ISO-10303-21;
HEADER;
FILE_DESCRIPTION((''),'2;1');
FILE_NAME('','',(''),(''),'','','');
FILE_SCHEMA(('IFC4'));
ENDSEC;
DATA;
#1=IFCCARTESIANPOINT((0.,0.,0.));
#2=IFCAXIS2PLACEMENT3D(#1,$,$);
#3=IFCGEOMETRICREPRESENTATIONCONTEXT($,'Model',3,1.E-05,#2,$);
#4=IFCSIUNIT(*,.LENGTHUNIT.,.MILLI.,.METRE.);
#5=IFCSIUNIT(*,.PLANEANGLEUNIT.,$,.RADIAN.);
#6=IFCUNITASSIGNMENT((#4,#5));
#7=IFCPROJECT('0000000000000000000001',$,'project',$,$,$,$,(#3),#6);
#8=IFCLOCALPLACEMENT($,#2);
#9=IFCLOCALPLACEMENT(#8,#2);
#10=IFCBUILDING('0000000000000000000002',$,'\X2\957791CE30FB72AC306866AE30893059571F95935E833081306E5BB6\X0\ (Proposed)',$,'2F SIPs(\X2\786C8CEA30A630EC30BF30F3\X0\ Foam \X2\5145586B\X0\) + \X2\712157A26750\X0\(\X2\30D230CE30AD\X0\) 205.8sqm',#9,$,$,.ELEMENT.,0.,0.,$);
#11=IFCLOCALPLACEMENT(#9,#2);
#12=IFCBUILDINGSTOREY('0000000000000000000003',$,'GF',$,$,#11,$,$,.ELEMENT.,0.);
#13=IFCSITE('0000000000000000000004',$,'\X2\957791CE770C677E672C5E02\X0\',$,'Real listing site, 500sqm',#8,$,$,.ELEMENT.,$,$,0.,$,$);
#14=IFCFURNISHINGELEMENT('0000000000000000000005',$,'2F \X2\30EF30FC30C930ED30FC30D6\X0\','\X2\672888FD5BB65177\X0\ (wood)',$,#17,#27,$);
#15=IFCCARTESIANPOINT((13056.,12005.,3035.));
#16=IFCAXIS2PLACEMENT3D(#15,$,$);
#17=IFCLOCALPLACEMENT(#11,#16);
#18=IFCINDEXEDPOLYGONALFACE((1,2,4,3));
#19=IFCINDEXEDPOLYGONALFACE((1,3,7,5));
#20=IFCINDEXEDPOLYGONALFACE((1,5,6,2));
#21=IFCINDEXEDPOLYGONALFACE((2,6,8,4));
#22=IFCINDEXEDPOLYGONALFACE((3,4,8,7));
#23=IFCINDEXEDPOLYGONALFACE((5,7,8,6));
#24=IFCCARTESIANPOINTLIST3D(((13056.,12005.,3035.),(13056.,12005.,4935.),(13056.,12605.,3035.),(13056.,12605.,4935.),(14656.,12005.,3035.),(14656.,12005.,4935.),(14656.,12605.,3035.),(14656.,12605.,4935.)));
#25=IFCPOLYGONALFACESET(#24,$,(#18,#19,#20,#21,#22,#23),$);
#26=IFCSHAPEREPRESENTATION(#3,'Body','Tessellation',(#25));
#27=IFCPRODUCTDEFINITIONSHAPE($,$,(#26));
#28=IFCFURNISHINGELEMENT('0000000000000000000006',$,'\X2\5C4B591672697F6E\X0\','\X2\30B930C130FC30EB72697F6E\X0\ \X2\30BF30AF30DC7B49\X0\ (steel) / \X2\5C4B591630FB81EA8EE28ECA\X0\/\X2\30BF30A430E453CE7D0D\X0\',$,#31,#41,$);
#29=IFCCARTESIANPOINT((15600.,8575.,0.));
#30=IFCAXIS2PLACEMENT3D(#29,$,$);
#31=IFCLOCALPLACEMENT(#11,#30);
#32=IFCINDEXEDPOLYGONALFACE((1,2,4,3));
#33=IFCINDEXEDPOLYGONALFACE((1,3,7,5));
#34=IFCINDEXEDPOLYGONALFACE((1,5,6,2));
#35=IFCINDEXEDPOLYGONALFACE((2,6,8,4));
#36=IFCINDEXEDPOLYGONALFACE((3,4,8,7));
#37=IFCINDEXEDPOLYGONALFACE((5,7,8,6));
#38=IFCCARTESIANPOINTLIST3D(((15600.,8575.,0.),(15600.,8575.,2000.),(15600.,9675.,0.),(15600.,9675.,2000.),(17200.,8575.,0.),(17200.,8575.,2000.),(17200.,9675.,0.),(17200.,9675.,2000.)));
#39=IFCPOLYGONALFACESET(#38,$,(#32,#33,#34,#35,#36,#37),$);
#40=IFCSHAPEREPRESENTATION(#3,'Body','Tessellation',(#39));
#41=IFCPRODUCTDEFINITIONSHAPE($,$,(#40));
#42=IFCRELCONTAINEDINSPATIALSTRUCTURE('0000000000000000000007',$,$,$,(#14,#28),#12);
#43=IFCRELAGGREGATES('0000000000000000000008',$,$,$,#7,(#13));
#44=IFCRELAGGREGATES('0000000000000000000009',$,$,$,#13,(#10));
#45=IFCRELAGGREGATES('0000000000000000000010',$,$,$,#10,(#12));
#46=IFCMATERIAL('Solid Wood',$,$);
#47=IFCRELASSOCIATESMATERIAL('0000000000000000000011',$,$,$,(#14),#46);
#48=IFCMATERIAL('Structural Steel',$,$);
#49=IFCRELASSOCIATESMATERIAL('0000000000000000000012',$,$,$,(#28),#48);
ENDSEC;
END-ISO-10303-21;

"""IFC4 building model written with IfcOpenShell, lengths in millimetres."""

from ifc_helpers import new_model, si_unit, frame, frame_2d, origin, place, context, project, spatial, rectangle, extrude, material, element, save


model = new_model("IFC4")

# Units and contexts
model_context = context("Model", 3, precision=1e-05, world=origin())
ifc_project = project(units=[si_unit("LENGTHUNIT", "METRE", prefix="MILLI"), si_unit("PLANEANGLEUNIT", "RADIAN")], contexts=[model_context])

# Site, building, storey
site_placement = place(None, origin())
site = spatial("IfcSite", under=ifc_project, at=site_placement, Name="長野県松本市", ObjectType="Real listing site, 500sqm", CompositionType="ELEMENT", RefElevation=0.0)
building_placement = place(site_placement, origin())
building = spatial("IfcBuilding", under=site, at=building_placement, Name="長野・犬と暮らす土間広めの家 (Proposed)", ObjectType="2F SIPs(硬質ウレタン Foam 充填) + 無垢材(ヒノキ) 205.8sqm", CompositionType="ELEMENT", ElevationOfRefHeight=0.0, ElevationOfTerrain=0.0)
storey_placement = place(building_placement, origin())
storey = spatial("IfcBuildingStorey", under=building, at=storey_placement, Name="GF", CompositionType="ELEMENT", Elevation=0.0)

# Shared definitions
ifc_material_1 = material(Name="Solid Wood")

# Shared definitions
ifc_material_2 = material(Name="Structural Steel")

# Furnishing elements
furnishing_1_placement = place(storey_placement, frame((13056.0, 12005.0, 3035.0)))
element("IfcFurnishingElement", 1, at=furnishing_1_placement, inside=storey, material=ifc_material_1, Name="2F ワードローブ", Description="木製家具 (wood)", context=model_context, shape_type="SweptSolid", body=[
    extrude(rectangle(XDim=1600.0, YDim=600.0, at=frame_2d((800.0, 300.0))), frame((13056.0, 12005.0, 3035.0)), (0.0, 0.0, 1.0), 1900.0),
])
furnishing_2_placement = place(storey_placement, frame((15600.0, 8575.0, 0.0)))
element("IfcFurnishingElement", 2, at=furnishing_2_placement, inside=storey, material=ifc_material_2, Name="屋外物置", Description="スチール物置 タクボ等 (steel) / 屋外・自転車/タイヤ収納", context=model_context, shape_type="SweptSolid", body=[
    extrude(rectangle(XDim=1600.0, YDim=1100.0, at=frame_2d((800.0, 550.0))), frame((15600.0, 8575.0, 0.0)), (0.0, 0.0, 1.0), 2000.0),
])

save(model, "model.ifc")
